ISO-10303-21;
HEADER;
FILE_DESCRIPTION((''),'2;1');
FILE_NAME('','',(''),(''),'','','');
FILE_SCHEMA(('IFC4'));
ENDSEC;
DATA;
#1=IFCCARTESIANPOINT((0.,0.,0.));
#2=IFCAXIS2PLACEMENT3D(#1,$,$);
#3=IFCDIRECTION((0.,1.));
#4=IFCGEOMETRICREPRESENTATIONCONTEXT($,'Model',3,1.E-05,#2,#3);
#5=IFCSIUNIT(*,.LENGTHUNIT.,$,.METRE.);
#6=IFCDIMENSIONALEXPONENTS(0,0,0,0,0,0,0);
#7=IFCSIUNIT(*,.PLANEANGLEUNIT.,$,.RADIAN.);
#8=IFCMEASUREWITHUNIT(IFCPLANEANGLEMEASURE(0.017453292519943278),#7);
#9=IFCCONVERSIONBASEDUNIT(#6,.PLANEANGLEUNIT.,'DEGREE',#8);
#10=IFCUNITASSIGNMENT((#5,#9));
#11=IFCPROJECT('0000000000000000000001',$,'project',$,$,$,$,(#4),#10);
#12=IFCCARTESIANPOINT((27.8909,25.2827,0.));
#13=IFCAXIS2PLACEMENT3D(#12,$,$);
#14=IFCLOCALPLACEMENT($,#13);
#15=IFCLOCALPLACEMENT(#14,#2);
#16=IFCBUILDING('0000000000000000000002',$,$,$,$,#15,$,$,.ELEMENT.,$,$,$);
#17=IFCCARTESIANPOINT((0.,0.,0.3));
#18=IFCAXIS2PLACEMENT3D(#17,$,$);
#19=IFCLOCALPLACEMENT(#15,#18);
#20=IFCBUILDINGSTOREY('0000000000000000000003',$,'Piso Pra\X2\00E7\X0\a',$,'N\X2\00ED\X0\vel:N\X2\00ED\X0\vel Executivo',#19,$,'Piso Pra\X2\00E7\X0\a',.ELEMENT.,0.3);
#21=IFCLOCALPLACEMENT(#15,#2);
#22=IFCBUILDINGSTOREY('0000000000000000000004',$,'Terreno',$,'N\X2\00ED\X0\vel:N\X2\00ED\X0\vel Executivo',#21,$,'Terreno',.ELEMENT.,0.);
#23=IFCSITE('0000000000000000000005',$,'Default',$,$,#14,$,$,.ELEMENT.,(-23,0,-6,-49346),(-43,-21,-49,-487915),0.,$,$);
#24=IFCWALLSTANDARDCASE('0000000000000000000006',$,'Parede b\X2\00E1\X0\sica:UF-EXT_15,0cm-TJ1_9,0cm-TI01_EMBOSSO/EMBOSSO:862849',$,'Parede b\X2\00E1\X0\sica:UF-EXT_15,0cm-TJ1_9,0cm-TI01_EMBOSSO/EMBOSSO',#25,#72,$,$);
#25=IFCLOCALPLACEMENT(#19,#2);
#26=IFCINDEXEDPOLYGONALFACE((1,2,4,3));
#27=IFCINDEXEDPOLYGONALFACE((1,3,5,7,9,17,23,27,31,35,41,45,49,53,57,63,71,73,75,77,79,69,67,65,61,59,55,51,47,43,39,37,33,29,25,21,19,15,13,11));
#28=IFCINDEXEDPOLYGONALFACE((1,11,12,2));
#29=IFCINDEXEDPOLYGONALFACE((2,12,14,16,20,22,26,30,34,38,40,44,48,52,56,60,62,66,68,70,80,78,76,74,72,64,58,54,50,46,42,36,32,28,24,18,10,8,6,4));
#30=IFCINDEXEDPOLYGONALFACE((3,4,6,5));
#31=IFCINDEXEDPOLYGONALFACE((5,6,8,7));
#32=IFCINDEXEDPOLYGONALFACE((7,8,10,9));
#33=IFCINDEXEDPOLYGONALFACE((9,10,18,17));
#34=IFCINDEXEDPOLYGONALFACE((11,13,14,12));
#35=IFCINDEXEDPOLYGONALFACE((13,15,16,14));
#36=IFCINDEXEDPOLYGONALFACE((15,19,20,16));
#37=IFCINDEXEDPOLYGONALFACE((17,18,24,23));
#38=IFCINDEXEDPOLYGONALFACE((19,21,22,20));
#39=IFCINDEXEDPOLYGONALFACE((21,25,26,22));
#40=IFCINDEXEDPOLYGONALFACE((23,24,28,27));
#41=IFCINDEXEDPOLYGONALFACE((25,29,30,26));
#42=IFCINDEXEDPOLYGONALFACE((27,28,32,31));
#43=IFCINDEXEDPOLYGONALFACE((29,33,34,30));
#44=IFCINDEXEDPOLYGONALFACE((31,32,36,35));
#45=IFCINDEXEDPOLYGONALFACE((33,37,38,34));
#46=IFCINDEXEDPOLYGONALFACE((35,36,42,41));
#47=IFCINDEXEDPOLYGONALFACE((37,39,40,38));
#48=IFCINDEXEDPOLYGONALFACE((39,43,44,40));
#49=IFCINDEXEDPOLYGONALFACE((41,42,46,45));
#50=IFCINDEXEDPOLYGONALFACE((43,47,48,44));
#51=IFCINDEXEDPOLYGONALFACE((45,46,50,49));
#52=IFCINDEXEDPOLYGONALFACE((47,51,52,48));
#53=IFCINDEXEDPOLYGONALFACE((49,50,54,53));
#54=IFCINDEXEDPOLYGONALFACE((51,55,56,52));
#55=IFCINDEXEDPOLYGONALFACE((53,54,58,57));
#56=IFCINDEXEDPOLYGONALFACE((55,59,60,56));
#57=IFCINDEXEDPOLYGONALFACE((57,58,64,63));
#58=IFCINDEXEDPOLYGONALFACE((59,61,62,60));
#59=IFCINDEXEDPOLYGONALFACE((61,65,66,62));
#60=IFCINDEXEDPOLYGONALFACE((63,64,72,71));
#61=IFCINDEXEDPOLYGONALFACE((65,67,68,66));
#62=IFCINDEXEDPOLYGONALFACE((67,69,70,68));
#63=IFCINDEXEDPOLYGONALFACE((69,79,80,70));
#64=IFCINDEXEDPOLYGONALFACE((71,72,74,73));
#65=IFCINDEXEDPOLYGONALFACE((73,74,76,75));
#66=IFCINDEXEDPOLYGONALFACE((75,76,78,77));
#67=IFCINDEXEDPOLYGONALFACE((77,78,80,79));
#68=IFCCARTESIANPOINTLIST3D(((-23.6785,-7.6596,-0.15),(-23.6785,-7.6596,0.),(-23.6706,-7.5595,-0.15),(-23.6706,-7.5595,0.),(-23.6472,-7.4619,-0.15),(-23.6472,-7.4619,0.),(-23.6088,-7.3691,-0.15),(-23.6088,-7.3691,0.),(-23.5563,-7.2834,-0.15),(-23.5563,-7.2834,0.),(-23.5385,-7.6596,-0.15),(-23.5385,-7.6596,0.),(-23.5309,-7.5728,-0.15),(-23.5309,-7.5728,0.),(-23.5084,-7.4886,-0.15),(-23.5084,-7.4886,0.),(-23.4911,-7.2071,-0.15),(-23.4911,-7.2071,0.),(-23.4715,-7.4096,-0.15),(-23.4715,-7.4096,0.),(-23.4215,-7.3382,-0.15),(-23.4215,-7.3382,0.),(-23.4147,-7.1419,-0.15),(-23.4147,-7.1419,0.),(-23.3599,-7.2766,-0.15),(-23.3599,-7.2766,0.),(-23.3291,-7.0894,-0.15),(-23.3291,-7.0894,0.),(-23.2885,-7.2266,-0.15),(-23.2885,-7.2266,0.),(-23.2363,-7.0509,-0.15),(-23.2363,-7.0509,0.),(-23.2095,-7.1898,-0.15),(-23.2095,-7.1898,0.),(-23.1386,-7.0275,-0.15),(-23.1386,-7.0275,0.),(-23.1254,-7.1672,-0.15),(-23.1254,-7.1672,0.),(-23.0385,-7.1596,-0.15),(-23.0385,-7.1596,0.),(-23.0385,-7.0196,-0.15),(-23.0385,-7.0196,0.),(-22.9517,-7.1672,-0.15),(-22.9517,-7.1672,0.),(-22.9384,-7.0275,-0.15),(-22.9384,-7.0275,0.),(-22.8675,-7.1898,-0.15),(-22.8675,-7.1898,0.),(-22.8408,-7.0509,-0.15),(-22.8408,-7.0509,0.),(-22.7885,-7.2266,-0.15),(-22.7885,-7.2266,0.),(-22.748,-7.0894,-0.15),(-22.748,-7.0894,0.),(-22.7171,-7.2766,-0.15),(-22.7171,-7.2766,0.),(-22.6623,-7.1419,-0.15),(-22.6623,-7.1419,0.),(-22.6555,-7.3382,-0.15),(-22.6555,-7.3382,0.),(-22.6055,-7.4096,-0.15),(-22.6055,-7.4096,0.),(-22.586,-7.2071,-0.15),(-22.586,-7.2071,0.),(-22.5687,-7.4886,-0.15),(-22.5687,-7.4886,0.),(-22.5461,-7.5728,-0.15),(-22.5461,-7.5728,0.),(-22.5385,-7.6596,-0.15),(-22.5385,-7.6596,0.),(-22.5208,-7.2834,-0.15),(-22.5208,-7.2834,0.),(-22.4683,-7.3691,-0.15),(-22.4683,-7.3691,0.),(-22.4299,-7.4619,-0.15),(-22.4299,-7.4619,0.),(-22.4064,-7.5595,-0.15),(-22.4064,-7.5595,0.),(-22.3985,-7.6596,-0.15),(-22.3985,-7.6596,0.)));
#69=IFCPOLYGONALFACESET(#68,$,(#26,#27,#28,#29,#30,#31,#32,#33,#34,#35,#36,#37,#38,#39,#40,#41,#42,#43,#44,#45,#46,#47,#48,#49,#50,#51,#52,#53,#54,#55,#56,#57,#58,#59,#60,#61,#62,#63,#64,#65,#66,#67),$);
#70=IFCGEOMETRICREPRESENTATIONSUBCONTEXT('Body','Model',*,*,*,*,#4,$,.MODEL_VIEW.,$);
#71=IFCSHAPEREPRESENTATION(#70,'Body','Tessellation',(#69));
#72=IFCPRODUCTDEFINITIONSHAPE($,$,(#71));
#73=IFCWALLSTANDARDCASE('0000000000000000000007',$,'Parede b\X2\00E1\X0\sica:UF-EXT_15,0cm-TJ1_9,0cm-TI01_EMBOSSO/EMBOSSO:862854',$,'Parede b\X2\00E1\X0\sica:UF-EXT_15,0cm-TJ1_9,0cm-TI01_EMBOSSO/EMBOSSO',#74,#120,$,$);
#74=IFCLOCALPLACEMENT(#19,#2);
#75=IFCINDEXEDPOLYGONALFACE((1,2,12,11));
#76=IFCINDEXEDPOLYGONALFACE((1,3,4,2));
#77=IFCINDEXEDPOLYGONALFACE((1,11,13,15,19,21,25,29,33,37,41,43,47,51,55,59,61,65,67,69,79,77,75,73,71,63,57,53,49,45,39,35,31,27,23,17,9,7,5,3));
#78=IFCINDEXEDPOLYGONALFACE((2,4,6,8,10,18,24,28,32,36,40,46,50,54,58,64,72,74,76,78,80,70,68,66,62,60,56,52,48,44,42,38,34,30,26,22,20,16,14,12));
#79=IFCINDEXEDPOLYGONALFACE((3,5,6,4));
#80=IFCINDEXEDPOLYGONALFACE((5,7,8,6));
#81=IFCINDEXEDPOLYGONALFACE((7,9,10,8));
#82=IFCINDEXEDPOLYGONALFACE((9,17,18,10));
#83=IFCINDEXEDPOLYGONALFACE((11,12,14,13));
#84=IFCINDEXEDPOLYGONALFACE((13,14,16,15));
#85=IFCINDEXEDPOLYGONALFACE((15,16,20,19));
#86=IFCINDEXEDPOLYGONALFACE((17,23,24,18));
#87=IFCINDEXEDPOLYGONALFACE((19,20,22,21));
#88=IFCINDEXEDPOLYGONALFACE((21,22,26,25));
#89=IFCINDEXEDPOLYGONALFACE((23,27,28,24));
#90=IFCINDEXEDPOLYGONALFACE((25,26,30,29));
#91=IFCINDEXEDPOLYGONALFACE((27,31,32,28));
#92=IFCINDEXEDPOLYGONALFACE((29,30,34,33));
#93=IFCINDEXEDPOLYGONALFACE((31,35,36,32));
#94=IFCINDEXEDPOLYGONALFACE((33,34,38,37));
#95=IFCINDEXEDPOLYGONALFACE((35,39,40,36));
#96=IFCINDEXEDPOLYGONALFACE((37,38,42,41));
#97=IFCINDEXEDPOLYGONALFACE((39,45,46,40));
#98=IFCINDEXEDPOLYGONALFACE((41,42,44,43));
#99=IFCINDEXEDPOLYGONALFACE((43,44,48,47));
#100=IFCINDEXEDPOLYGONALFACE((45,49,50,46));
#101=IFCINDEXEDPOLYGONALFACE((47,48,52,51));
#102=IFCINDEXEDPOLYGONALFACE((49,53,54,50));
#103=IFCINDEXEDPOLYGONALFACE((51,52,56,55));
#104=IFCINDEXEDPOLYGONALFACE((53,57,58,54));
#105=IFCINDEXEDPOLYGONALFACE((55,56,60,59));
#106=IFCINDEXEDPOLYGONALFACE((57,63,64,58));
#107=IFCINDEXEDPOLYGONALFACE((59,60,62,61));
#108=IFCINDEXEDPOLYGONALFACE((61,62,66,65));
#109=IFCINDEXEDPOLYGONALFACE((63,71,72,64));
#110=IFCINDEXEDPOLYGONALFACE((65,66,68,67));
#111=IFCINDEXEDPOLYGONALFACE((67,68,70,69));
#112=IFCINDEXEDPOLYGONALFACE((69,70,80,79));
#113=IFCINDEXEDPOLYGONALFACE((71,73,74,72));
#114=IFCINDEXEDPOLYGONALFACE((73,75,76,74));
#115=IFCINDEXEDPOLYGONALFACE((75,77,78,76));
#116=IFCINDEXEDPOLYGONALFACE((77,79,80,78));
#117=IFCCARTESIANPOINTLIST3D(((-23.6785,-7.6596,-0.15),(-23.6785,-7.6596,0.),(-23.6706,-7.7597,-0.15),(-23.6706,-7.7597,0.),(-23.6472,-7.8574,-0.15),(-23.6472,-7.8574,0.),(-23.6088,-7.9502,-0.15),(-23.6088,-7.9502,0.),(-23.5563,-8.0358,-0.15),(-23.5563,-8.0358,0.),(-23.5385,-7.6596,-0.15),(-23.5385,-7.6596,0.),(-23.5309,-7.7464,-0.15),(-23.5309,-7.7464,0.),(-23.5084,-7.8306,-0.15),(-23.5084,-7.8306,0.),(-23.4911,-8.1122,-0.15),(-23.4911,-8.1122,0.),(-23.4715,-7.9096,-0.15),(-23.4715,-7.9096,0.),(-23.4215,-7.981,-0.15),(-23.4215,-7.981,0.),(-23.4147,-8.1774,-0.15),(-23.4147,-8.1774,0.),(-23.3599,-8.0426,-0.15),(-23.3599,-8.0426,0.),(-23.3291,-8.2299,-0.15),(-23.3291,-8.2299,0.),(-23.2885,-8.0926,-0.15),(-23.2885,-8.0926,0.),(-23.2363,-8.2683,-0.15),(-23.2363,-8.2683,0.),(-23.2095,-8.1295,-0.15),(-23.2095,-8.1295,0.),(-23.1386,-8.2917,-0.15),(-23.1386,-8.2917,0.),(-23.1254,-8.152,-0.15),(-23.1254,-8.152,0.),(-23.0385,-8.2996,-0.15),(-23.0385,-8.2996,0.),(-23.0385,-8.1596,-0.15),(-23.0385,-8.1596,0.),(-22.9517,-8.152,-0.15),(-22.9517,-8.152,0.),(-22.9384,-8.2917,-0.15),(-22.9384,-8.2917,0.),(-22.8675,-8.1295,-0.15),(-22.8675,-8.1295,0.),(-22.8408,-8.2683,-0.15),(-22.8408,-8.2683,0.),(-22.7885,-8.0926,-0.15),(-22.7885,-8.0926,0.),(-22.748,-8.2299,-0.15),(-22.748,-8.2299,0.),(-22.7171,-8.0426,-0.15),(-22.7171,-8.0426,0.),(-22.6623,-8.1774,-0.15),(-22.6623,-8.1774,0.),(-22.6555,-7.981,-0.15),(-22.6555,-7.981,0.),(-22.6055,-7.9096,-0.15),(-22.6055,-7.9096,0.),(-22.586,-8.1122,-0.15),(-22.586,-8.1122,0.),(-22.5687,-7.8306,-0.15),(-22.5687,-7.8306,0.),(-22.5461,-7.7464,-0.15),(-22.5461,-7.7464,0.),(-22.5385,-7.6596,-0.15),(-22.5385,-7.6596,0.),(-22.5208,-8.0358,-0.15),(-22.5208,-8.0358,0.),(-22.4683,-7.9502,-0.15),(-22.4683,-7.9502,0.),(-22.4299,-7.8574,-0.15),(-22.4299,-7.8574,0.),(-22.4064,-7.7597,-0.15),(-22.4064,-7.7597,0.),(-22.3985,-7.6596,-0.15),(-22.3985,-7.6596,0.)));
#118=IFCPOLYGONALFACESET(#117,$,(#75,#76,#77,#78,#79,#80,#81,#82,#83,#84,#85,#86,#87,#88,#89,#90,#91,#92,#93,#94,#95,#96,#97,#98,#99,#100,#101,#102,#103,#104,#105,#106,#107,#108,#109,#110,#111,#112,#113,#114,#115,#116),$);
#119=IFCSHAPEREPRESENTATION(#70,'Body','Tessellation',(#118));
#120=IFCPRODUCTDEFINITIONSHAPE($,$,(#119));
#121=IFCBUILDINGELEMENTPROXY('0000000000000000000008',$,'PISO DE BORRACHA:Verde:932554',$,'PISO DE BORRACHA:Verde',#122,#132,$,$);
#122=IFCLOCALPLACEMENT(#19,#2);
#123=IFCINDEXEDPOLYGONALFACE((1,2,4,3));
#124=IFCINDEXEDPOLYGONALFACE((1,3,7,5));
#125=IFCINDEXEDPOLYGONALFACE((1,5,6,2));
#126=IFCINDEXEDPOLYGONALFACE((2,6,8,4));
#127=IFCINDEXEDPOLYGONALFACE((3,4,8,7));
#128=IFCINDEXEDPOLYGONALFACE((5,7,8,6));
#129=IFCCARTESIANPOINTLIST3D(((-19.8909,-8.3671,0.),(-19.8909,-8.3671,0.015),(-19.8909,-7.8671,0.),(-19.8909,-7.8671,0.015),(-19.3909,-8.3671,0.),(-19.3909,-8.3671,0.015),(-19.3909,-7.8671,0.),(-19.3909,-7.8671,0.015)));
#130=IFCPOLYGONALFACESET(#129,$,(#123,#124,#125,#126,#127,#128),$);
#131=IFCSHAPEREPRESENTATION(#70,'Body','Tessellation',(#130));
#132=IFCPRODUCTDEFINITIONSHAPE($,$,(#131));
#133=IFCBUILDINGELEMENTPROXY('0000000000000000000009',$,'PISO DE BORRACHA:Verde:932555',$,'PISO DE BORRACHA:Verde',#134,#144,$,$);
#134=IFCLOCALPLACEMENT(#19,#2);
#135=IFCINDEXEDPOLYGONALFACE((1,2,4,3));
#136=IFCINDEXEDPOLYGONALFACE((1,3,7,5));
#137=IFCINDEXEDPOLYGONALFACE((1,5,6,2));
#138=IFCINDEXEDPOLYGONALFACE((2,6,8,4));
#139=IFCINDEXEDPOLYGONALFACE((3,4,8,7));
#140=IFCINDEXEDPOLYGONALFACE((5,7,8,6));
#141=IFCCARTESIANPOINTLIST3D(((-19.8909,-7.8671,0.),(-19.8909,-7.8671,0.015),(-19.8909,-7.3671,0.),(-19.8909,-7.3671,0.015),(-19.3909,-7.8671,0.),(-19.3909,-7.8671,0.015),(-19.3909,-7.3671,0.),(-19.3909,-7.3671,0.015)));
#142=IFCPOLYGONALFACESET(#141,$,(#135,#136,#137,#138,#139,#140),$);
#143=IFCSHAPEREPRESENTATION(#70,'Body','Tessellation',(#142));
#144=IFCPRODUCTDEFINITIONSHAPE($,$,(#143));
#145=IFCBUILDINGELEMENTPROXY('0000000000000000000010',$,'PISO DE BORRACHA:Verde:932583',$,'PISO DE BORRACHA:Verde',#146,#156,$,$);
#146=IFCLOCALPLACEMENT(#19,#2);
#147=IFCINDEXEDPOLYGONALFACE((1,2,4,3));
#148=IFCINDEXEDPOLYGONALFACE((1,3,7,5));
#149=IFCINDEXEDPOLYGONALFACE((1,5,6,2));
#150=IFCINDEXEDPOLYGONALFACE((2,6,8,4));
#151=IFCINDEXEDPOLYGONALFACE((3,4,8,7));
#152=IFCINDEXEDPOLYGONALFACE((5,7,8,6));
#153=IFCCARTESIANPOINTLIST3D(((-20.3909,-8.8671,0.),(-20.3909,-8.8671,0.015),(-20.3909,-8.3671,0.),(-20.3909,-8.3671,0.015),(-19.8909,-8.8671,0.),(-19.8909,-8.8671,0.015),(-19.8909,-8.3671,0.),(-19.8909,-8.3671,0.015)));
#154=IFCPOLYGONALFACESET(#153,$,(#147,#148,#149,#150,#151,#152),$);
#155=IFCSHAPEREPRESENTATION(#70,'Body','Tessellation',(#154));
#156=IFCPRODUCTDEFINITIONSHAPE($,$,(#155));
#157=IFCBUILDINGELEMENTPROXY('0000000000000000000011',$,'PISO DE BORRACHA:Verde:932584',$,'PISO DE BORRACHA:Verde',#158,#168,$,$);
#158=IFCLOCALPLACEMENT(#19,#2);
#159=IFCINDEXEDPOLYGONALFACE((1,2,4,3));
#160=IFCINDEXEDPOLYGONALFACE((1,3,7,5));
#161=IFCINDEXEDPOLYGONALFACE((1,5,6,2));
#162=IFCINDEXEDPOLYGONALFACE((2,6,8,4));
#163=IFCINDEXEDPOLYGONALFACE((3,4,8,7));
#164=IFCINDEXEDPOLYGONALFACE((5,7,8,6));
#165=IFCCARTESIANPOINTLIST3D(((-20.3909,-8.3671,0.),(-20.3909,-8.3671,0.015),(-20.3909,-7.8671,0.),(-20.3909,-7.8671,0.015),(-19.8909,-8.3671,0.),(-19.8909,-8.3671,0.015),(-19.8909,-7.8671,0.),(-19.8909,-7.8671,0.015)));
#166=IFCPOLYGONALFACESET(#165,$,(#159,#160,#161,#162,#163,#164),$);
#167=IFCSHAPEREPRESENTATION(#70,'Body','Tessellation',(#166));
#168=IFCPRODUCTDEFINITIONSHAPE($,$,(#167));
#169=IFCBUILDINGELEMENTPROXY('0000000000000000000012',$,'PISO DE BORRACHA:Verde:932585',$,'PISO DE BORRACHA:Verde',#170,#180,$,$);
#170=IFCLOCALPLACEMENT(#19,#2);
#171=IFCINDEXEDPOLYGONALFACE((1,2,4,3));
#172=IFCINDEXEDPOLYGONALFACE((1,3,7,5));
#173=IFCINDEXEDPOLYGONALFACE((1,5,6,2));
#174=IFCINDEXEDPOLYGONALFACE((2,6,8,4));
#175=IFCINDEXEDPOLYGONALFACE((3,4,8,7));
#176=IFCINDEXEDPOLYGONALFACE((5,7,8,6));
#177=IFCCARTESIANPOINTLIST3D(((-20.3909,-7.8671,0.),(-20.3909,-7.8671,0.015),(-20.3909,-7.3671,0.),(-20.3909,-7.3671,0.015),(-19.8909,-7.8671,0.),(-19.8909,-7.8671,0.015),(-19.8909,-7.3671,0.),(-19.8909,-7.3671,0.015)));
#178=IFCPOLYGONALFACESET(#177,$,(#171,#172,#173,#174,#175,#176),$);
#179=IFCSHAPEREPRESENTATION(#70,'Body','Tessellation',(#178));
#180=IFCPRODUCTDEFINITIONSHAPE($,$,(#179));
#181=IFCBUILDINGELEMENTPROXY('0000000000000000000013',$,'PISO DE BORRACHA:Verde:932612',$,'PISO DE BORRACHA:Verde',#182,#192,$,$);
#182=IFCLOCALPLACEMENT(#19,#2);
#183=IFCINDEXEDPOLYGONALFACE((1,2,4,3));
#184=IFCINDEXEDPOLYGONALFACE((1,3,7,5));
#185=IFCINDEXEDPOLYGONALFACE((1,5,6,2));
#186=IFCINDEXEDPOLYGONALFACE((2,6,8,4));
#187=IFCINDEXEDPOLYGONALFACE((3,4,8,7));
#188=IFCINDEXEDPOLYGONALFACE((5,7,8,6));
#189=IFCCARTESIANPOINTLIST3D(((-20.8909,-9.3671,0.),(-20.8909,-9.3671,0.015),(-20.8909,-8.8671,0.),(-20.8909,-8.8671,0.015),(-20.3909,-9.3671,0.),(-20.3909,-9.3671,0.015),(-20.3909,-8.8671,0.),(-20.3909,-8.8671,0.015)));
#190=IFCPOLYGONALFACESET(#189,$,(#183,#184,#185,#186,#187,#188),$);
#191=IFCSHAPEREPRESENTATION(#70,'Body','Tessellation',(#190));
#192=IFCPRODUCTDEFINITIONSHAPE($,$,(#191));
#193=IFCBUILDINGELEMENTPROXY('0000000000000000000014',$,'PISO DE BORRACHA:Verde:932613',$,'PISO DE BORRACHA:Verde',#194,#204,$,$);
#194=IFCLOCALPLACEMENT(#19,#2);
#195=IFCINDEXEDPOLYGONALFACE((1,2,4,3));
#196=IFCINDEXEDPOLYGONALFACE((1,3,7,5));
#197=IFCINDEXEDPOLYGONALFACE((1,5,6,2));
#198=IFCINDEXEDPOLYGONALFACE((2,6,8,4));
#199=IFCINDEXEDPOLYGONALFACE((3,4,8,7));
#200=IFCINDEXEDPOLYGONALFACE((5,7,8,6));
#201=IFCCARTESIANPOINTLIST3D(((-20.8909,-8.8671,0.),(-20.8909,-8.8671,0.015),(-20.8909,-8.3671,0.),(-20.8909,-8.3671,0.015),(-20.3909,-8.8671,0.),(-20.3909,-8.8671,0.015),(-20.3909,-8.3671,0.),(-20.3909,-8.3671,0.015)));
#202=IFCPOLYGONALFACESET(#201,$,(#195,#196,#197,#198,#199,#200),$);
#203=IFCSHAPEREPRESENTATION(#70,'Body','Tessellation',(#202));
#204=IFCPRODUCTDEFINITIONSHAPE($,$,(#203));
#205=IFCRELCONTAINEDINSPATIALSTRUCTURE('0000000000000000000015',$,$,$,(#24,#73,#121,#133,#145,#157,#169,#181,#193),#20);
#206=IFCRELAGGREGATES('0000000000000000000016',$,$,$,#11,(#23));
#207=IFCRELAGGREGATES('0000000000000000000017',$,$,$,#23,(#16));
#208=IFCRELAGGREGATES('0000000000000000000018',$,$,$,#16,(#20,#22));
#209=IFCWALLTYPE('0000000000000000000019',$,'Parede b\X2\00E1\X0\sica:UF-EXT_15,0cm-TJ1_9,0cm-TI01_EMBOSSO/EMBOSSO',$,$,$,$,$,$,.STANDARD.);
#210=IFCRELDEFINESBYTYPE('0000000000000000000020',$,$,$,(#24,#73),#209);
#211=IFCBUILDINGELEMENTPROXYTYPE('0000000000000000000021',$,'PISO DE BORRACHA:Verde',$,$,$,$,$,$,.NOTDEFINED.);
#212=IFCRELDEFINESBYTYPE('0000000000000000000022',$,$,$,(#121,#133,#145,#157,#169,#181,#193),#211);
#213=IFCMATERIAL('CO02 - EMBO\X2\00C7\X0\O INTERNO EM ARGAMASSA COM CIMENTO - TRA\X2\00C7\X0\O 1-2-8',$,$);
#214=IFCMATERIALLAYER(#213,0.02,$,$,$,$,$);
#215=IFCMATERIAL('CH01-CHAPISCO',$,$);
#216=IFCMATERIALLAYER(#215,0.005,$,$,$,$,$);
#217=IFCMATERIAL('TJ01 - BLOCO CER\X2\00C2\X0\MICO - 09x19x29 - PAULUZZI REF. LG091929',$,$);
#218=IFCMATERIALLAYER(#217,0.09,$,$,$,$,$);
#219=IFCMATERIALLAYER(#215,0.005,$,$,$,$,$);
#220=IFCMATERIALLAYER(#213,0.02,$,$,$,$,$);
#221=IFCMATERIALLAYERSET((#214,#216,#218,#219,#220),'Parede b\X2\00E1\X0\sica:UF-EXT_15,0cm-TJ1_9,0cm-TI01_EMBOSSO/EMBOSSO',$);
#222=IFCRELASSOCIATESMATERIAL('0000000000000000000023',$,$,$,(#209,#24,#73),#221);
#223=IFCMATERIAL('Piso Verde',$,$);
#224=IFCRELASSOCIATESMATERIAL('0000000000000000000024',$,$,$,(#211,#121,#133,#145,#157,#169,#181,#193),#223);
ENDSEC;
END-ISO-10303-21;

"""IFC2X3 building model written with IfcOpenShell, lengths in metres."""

from ifc_helpers import new_model, entity, si_unit, converted_unit, direction, frame, frame_2d, origin, origin_2d_with_axis, place, context, subcontext, project, spatial, polyline, circle_curve, parameter, trimmed, segment, composite_curve, rectangle, outline, extrude, source, transform, mapped, material, layer, layer_set, layer_usage, type_object, type_shapes, element, save


model = new_model("IFC2X3")

# Units and contexts
model_context = context("Model", 3, precision=1e-05, world=origin(), true_north=direction((0.0, 1.0)))
body_context = subcontext(model_context, "Body", "Model", "MODEL_VIEW")
ifc_project = project(units=[si_unit("LENGTHUNIT", "METRE"), converted_unit("PLANEANGLEUNIT", "DEGREE", entity("IfcPlaneAngleMeasure", 0.017453292519943278), si_unit("PLANEANGLEUNIT", "RADIAN"), dimensions=[0, 0, 0, 0, 0, 0, 0])], contexts=[model_context])

# Site, building, storey
site_placement = place(None, frame((27.8909, 25.2827, 0.0)))
site = spatial("IfcSite", under=ifc_project, at=site_placement, Name="Default", CompositionType="ELEMENT", RefLatitude=(-23, 0, -6, -49346), RefLongitude=(-43, -21, -49, -487915), RefElevation=0.0)
building_placement = place(site_placement, origin())
building = spatial("IfcBuilding", under=site, at=building_placement, CompositionType="ELEMENT")
storey_1_placement = place(building_placement, frame((0.0, 0.0, 0.3)))
storey_1 = spatial("IfcBuildingStorey", under=building, at=storey_1_placement, Name="Piso Praça", ObjectType="Nível:Nível Executivo", LongName="Piso Praça", CompositionType="ELEMENT", Elevation=0.3)

# Walls
ifc_material_1 = material(Name="CO02 - EMBOÇO INTERNO EM ARGAMASSA COM CIMENTO - TRAÇO 1-2-8")
ifc_layer_1 = layer(ifc_material_1, 0.02)
ifc_material_2 = material(Name="CH01-CHAPISCO")
ifc_layer_2 = layer(ifc_material_2, 0.005)
ifc_material_3 = material(Name="TJ01 - BLOCO CERÂMICO - 09x19x29 - PAULUZZI REF. LG091929")
ifc_layer_3 = layer(ifc_material_3, 0.09)
ifc_layer_4 = layer(ifc_material_2, 0.005)
ifc_layer_5 = layer(ifc_material_1, 0.02)
ifc_layer_set_1 = layer_set([ifc_layer_1, ifc_layer_2, ifc_layer_3, ifc_layer_4, ifc_layer_5], Name="Parede básica:UF-EXT_15,0cm-TJ1_9,0cm-TI01_EMBOSSO/EMBOSSO")
ifc_layer_usage_1 = layer_usage(ifc_layer_set_1, "AXIS2", "NEGATIVE", 0.07)
wall_type_1 = type_object("IfcWallType", Name="Parede básica:UF-EXT_15,0cm-TJ1_9,0cm-TI01_EMBOSSO/EMBOSSO", PredefinedType="STANDARD", material=ifc_layer_set_1)
wall_1_placement = place(storey_1_placement, frame((-22.4685, -7.6596, -0.15)))
element("IfcWallStandardCase", 1, at=wall_1_placement, inside=storey_1, type_object=wall_type_1, material=ifc_layer_usage_1, Name="Parede básica:UF-EXT_15,0cm-TJ1_9,0cm-TI01_EMBOSSO/EMBOSSO:862849", ObjectType="Parede básica:UF-EXT_15,0cm-TJ1_9,0cm-TI01_EMBOSSO/EMBOSSO", context=body_context, shape_type="SweptSolid", body=[
    extrude(outline(composite_curve([segment(trimmed(circle_curve(frame_2d((-0.57, 0.0), x_axis=(1.0, 0.0)), 0.5), [parameter(0.0)], [parameter(180.0)], True, "PARAMETER"), False, "CONTINUOUS"), segment(polyline([(-0.07, 0.0), (0.07, 0.0)]), True, "CONTINUOUS"), segment(trimmed(circle_curve(frame_2d((-0.57, 0.0), x_axis=(1.0, 0.0)), 0.64), [parameter(0.0)], [parameter(180.0)], True, "PARAMETER"), True, "CONTINUOUS"), segment(polyline([(-1.21, 0.0), (-1.07, 0.0)]), True, "CONTINUOUS")], self_intersect=False)), origin(), (0.0, 0.0, 1.0), 0.15),
])
wall_2_placement = place(storey_1_placement, frame((-23.6085, -7.6596, -0.15)))
element("IfcWallStandardCase", 2, at=wall_2_placement, inside=storey_1, type_object=wall_type_1, material=ifc_layer_usage_1, Name="Parede básica:UF-EXT_15,0cm-TJ1_9,0cm-TI01_EMBOSSO/EMBOSSO:862854", ObjectType="Parede básica:UF-EXT_15,0cm-TJ1_9,0cm-TI01_EMBOSSO/EMBOSSO", context=body_context, shape_type="SweptSolid", body=[
    extrude(outline(composite_curve([segment(trimmed(circle_curve(frame_2d((0.57, 0.0), x_axis=(1.0, 0.0)), 0.5), [parameter(180.0)], [parameter(0.0)], True, "PARAMETER"), False, "CONTINUOUS"), segment(polyline([(0.07, 0.0), (-0.07, 0.0)]), True, "CONTINUOUS"), segment(trimmed(circle_curve(frame_2d((0.57, 0.0), x_axis=(1.0, 0.0)), 0.64), [parameter(180.0)], [parameter(0.0)], True, "PARAMETER"), True, "CONTINUOUS"), segment(polyline([(1.21, 0.0), (1.07, 0.0)]), True, "CONTINUOUS")], self_intersect=False)), origin(), (0.0, 0.0, 1.0), 0.15),
])

# Shared definitions
storey_2_placement = place(building_placement, origin())
storey_2 = spatial("IfcBuildingStorey", under=building, at=storey_2_placement, Name="Terreno", ObjectType="Nível:Nível Executivo", LongName="Terreno", CompositionType="ELEMENT", Elevation=0.0)

# Building element proxies
ifc_material_4 = material(Name="Piso Verde")
building_element_proxy_type_1 = type_object("IfcBuildingElementProxyType", Name="PISO DE BORRACHA:Verde", PredefinedType="NOTDEFINED", material=ifc_material_4)
shared_shape_1 = source(origin(), body_context, "Body", "SweptSolid", [
    extrude(rectangle(XDim=0.5, YDim=0.5, at=origin_2d_with_axis()), frame((0.25, 0.25, 0.0), z_axis=(0.0, 0.0, 1.0), x_axis=(-1.0, 0.0, 0.0)), (0.0, 0.0, 1.0), 0.015),
])
type_shapes(building_element_proxy_type_1, [shared_shape_1])
for number, where, z_axis, x_axis, name in (
    (3, (-19.8909, -7.8671, 0.0), (0.0, 0.0, 1.0), (0.0, -1.0, 0.0), "PISO DE BORRACHA:Verde:932554"),
    (4, (-19.8909, -7.3671, 0.0), (0.0, 0.0, 1.0), (0.0, -1.0, 0.0), "PISO DE BORRACHA:Verde:932555"),
    (5, (-20.3909, -8.3671, 0.0), (0.0, 0.0, 1.0), (0.0, -1.0, 0.0), "PISO DE BORRACHA:Verde:932583"),
    (6, (-20.3909, -7.8671, 0.0), (0.0, 0.0, 1.0), (0.0, -1.0, 0.0), "PISO DE BORRACHA:Verde:932584"),
    (7, (-20.3909, -7.3671, 0.0), (0.0, 0.0, 1.0), (0.0, -1.0, 0.0), "PISO DE BORRACHA:Verde:932585"),
    (8, (-20.8909, -8.8671, 0.0), (0.0, 0.0, 1.0), (0.0, -1.0, 0.0), "PISO DE BORRACHA:Verde:932612"),
    (9, (-20.8909, -8.3671, 0.0), (0.0, 0.0, 1.0), (0.0, -1.0, 0.0), "PISO DE BORRACHA:Verde:932613"),
):
    element("IfcBuildingElementProxy", number, at=place(storey_1_placement, frame(where, z_axis=z_axis, x_axis=x_axis)), inside=storey_1, type_object=building_element_proxy_type_1, material=ifc_material_4, Name=name, ObjectType="PISO DE BORRACHA:Verde", context=body_context, shape_type="MappedRepresentation", body=[
        mapped(shared_shape_1, transform((0.0, 0.0, 0.0), scale=1.0)),
    ])

save(model, "model.ifc")
